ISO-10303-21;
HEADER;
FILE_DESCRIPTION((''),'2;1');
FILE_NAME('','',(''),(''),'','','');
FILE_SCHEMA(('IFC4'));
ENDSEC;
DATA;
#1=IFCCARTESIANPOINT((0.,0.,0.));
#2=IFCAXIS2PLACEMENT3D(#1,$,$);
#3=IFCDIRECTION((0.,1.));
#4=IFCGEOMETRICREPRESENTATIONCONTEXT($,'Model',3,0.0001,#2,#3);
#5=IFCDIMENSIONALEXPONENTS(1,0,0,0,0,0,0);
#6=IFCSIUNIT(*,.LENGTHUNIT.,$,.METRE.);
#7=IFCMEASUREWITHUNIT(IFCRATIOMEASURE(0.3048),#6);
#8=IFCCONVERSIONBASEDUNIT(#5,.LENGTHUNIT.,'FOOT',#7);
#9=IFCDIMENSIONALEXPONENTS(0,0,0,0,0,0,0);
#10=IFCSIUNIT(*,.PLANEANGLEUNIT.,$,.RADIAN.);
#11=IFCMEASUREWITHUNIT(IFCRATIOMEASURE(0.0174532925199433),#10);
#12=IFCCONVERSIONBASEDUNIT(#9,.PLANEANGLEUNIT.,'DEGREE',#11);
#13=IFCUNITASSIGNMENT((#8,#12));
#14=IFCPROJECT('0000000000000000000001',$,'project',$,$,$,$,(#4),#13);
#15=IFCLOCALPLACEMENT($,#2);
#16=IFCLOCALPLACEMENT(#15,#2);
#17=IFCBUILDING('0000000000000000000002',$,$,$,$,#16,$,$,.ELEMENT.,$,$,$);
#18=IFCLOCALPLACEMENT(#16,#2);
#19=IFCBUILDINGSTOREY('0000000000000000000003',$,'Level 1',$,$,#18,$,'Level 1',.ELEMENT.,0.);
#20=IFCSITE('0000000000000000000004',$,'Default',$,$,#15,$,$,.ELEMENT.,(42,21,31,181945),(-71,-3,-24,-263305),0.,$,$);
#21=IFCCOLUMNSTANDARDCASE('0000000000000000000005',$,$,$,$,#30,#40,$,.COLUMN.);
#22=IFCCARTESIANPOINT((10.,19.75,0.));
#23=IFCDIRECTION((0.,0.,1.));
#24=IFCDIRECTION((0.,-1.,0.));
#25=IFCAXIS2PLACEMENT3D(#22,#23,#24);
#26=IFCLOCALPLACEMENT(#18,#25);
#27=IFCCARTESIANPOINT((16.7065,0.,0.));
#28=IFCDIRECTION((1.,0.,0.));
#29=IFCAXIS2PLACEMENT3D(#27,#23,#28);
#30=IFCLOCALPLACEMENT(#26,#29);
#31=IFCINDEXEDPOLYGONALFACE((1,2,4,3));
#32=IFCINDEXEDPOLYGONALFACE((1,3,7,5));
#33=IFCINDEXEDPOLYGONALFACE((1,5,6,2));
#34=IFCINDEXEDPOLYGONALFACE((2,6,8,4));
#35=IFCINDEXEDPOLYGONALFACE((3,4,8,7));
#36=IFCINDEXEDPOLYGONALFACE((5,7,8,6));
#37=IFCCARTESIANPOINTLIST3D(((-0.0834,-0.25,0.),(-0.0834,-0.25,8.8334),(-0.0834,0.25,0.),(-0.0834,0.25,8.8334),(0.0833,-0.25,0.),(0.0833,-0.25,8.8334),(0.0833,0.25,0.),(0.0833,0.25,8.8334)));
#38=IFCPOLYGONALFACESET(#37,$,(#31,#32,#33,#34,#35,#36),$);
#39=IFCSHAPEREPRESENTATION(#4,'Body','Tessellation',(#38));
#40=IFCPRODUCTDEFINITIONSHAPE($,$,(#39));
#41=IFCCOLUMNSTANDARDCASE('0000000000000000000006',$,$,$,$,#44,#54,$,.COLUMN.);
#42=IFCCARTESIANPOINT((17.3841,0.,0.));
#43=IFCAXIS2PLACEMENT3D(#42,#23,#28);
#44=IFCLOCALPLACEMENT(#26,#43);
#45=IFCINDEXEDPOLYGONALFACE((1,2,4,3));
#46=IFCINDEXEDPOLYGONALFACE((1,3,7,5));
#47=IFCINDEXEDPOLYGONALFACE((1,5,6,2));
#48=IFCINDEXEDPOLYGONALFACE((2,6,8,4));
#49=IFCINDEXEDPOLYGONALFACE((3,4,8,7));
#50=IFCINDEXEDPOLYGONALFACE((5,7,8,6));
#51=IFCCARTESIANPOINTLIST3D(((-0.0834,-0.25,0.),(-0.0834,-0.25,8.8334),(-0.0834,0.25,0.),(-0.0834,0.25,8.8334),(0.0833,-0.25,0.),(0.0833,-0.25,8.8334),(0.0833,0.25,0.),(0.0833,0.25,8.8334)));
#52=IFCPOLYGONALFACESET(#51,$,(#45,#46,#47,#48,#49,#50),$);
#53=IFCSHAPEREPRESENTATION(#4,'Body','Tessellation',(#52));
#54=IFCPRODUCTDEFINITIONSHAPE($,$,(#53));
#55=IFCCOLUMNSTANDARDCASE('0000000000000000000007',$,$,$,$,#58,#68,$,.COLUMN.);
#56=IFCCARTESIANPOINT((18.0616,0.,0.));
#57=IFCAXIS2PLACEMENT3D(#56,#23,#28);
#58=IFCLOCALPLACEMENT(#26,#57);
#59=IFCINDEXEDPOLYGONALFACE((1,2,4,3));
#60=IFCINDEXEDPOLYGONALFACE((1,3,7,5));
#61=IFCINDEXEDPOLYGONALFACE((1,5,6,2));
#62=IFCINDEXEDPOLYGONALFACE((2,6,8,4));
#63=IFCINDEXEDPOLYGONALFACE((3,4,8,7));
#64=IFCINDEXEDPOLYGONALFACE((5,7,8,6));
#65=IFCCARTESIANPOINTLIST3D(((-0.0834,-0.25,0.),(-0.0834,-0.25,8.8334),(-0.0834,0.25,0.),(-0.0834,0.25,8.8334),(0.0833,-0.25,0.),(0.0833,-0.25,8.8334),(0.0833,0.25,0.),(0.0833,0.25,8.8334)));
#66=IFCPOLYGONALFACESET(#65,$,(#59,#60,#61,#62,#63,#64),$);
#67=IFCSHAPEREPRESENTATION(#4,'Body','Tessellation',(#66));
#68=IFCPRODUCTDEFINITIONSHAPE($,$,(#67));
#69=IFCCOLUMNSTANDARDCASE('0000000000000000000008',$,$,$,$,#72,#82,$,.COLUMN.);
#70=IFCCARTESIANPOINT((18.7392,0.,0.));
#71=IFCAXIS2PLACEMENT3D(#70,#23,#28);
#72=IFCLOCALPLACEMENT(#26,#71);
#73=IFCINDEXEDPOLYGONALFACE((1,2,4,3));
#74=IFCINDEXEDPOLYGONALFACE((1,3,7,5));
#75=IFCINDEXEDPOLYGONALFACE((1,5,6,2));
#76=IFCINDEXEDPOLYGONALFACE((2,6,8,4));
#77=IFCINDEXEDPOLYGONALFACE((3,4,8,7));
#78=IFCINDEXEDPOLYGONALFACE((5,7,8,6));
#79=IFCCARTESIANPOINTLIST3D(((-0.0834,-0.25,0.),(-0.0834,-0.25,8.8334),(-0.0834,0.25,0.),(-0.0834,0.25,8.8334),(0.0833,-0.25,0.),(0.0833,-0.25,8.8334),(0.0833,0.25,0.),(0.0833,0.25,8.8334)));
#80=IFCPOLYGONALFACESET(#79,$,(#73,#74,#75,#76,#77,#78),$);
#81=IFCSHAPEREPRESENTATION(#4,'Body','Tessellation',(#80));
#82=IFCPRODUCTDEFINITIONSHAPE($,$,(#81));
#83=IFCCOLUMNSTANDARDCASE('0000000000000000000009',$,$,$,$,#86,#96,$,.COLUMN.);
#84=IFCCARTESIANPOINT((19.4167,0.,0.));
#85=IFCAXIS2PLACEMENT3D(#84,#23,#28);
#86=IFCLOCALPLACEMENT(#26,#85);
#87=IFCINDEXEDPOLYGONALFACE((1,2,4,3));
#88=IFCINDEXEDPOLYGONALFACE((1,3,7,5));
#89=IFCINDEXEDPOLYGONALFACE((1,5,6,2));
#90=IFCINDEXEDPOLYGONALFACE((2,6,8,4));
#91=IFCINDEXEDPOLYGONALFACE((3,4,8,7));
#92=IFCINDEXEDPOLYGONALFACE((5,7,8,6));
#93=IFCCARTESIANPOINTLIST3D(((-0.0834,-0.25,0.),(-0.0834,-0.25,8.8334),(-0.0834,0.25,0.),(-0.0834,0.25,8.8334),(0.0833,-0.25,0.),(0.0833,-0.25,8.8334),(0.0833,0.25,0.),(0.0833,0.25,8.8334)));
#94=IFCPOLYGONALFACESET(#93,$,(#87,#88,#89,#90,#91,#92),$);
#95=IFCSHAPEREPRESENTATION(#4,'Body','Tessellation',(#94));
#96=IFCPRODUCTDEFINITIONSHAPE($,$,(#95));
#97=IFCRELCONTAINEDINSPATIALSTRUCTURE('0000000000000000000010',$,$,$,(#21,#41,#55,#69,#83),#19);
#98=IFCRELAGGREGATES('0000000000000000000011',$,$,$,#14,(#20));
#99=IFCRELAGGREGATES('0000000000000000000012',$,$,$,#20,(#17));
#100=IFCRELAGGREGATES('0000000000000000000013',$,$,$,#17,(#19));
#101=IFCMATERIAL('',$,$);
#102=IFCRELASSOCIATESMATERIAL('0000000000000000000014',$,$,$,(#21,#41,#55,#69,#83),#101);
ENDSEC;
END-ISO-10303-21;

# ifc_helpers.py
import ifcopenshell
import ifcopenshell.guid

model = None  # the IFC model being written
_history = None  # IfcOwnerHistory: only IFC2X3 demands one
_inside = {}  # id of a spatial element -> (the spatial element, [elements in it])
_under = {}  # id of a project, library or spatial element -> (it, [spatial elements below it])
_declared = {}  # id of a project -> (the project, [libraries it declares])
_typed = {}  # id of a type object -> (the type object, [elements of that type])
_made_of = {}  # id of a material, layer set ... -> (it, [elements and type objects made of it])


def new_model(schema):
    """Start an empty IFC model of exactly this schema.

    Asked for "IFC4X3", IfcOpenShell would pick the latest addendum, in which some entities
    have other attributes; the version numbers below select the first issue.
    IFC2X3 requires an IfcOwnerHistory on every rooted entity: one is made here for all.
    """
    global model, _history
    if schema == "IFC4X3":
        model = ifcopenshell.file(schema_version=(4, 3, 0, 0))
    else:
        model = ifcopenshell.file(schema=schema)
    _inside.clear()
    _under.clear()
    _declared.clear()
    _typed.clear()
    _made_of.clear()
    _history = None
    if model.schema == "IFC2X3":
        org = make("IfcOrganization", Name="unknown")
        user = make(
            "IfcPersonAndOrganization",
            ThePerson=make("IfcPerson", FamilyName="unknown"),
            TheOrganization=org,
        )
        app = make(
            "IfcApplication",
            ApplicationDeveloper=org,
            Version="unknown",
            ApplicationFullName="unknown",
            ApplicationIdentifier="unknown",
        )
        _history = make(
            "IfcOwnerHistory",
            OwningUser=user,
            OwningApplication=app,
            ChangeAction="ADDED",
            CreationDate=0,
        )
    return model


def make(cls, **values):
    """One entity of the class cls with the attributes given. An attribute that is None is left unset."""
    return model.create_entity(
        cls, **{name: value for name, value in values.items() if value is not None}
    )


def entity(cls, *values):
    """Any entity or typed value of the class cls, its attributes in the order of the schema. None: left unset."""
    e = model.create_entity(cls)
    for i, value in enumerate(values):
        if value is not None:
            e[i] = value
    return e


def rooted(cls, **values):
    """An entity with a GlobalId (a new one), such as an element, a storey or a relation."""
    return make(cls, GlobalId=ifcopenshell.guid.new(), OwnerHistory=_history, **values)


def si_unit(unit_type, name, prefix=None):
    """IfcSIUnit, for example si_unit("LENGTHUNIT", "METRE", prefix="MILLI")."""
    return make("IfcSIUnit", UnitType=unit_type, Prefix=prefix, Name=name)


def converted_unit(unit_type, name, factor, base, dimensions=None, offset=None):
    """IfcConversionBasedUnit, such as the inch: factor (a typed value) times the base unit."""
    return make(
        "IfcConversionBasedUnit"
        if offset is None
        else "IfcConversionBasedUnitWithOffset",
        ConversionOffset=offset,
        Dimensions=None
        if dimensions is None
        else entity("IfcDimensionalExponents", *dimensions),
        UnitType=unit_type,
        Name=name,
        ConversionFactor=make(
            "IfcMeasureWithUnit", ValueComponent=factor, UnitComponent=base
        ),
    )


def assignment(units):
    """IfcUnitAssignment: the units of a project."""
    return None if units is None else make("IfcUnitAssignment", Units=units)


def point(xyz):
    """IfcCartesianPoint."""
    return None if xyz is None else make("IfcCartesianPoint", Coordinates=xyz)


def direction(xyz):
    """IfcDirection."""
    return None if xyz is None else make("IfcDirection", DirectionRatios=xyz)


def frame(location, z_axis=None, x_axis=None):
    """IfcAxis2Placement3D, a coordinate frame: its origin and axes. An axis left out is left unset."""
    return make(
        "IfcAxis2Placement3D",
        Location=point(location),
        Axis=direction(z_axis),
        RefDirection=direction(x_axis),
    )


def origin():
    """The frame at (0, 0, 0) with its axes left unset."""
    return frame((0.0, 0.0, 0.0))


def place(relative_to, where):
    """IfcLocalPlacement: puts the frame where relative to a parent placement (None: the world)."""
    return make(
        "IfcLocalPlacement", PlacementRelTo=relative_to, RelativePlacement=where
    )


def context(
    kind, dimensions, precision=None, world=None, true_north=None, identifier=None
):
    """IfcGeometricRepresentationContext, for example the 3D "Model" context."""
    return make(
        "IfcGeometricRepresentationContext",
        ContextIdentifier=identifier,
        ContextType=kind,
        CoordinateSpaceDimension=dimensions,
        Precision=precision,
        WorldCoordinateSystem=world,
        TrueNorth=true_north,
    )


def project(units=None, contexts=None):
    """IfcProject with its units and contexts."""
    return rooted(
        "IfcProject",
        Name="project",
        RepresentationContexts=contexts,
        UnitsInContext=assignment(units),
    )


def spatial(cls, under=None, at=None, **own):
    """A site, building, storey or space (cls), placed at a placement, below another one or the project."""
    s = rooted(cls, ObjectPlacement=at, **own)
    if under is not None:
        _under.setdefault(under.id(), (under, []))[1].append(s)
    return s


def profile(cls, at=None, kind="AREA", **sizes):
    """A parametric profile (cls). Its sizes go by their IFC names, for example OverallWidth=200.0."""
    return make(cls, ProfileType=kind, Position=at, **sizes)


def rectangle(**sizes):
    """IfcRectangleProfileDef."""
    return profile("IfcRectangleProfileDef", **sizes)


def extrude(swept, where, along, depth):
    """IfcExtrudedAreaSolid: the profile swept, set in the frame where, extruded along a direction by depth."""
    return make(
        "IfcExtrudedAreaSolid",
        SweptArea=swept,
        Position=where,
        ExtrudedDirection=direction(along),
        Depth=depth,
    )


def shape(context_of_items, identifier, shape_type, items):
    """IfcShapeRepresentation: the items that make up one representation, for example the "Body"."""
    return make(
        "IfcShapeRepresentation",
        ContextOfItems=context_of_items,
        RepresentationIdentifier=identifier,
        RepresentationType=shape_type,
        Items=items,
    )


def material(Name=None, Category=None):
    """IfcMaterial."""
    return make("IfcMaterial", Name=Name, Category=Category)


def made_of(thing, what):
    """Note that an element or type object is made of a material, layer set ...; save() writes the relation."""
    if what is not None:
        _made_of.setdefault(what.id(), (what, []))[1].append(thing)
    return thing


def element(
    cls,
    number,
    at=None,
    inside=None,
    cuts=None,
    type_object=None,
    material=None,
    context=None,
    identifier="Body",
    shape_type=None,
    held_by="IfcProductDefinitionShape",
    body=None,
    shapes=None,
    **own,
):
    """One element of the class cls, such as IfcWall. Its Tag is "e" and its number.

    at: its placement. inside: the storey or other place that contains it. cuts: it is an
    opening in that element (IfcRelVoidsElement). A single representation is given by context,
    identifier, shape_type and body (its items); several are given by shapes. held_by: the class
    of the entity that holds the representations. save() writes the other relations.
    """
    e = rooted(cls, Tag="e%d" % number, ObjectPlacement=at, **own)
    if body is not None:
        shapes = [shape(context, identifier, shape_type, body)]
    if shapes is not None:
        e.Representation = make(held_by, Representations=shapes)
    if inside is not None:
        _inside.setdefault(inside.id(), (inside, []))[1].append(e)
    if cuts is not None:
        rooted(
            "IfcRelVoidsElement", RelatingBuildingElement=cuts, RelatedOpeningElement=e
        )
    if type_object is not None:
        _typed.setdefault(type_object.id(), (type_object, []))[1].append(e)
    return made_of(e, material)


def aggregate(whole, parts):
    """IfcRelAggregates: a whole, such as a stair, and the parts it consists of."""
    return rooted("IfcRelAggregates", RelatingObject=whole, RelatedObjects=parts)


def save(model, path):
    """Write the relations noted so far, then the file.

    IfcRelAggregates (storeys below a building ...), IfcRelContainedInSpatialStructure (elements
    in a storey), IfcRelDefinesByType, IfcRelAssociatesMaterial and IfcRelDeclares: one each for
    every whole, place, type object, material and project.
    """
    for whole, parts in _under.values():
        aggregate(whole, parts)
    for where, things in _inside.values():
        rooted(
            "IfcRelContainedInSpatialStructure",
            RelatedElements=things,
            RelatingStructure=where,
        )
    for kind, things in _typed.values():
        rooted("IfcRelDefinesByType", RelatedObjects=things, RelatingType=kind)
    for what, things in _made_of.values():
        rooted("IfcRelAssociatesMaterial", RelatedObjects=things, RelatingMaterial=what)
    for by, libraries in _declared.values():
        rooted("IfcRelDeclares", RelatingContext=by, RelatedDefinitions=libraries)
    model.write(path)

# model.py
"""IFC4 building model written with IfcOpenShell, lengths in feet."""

from ifc_helpers import new_model, entity, si_unit, converted_unit, direction, frame, origin, place, context, project, spatial, rectangle, extrude, material, element, save


model = new_model("IFC4")

# Units and contexts
model_context = context("Model", 3, precision=0.0001, world=origin(), true_north=direction((0.0, 1.0)))
ifc_project = project(units=[converted_unit("LENGTHUNIT", "FOOT", entity("IfcRatioMeasure", 0.3048), si_unit("LENGTHUNIT", "METRE"), dimensions=[1, 0, 0, 0, 0, 0, 0]), converted_unit("PLANEANGLEUNIT", "DEGREE", entity("IfcRatioMeasure", 0.0174532925199433), si_unit("PLANEANGLEUNIT", "RADIAN"), dimensions=[0, 0, 0, 0, 0, 0, 0])], contexts=[model_context])

# Site, building, storey
site_placement = place(None, origin())
site = spatial("IfcSite", under=ifc_project, at=site_placement, Name="Default", CompositionType="ELEMENT", RefLatitude=(42, 21, 31, 181945), RefLongitude=(-71, -3, -24, -263305), RefElevation=0.0)
building_placement = place(site_placement, origin())
building = spatial("IfcBuilding", under=site, at=building_placement, CompositionType="ELEMENT")
storey_placement = place(building_placement, origin())
storey = spatial("IfcBuildingStorey", under=building, at=storey_placement, Name="Level 1", LongName="Level 1", CompositionType="ELEMENT", Elevation=0.0)

# Columns
ifc_material_1 = material(Name="")
placement_1 = place(storey_placement, frame((10.0, 19.75, 0.0), z_axis=(0.0, 0.0, 1.0), x_axis=(0.0, -1.0, 0.0)))
for number, where, z_axis, x_axis in (
    (1, (16.7065, 0.0, 0.0), (0.0, 0.0, 1.0), (1.0, 0.0, 0.0)),
    (2, (17.3841, 0.0, 0.0), (0.0, 0.0, 1.0), (1.0, 0.0, 0.0)),
    (3, (18.0616, 0.0, 0.0), (0.0, 0.0, 1.0), (1.0, 0.0, 0.0)),
    (4, (18.7392, 0.0, 0.0), (0.0, 0.0, 1.0), (1.0, 0.0, 0.0)),
    (5, (19.4167, 0.0, 0.0), (0.0, 0.0, 1.0), (1.0, 0.0, 0.0)),
):
    element("IfcColumnStandardCase", number, at=place(placement_1, frame(where, z_axis=z_axis, x_axis=x_axis)), inside=storey, material=ifc_material_1, PredefinedType="COLUMN", context=model_context, shape_type="SweptSolid", body=[
        extrude(rectangle(XDim=0.1667, YDim=0.5), origin(), (0.0, 0.0, 1.0), 8.8334),
    ])

save(model, "model.ifc")
